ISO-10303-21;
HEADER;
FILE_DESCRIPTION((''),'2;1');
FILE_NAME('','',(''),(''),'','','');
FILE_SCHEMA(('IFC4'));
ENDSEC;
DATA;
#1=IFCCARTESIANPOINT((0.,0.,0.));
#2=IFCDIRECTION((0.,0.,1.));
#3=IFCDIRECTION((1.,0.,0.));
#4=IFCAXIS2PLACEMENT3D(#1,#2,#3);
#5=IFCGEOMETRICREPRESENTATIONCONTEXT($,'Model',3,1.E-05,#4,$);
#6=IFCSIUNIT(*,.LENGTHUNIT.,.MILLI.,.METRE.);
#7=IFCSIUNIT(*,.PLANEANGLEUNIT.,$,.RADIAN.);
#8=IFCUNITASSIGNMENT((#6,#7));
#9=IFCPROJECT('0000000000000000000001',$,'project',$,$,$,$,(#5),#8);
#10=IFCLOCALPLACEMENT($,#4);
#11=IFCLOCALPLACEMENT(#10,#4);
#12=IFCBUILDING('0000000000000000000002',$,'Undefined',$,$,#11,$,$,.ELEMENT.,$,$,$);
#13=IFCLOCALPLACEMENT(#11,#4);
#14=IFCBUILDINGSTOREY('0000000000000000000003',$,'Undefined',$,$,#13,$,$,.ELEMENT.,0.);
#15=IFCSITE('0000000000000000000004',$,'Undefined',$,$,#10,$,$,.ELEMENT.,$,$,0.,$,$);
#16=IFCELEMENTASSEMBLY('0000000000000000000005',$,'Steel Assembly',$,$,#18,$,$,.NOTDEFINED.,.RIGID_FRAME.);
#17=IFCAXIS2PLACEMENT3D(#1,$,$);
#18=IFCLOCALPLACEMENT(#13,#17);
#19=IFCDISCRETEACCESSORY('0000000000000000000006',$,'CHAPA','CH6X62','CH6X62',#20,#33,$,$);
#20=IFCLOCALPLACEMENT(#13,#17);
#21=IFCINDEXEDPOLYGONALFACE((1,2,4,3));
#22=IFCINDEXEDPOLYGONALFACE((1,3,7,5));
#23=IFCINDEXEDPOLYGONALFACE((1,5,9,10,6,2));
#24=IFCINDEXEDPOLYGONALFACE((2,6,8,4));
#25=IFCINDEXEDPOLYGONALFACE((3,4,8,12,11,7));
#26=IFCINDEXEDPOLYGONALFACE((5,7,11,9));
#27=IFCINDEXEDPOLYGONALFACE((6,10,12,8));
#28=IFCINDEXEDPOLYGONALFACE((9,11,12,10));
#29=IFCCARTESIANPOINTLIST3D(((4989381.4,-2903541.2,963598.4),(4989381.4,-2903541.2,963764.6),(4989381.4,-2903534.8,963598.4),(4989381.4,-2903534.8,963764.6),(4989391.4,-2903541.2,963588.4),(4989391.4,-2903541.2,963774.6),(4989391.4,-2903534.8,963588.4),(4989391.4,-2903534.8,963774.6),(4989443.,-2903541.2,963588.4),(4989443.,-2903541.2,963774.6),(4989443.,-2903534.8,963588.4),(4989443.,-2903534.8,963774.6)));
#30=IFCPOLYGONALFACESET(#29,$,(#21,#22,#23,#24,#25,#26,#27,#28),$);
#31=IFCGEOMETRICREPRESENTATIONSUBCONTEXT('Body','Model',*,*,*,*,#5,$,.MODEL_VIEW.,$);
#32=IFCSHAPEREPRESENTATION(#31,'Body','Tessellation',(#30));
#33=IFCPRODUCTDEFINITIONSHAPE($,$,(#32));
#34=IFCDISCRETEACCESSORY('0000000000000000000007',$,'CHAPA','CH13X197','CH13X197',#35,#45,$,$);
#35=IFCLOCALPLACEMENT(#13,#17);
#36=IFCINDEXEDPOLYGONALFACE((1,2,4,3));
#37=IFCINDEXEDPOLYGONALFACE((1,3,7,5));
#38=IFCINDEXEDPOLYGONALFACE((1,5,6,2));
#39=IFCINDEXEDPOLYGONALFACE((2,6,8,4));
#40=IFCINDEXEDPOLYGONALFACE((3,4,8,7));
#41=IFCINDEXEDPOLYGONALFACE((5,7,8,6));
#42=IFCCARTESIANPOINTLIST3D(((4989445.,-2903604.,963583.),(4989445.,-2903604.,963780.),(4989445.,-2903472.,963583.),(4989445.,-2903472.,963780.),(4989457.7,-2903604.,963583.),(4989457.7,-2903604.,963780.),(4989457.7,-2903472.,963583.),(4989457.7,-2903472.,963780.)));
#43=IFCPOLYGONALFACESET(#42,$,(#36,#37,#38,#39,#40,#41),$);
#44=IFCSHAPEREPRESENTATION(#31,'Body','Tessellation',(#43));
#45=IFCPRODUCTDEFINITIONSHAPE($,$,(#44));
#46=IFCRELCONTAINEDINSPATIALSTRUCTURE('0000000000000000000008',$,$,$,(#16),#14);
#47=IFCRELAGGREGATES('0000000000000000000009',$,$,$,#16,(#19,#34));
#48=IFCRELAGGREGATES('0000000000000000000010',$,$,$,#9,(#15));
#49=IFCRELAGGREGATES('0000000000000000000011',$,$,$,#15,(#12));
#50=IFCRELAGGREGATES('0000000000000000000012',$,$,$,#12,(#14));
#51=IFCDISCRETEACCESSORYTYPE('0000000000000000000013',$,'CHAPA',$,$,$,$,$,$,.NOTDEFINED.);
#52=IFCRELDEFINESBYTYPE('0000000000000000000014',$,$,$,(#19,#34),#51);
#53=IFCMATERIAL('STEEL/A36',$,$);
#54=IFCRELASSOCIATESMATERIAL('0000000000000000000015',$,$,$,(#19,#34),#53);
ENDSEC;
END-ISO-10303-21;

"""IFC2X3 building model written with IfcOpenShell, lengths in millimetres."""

from ifc_helpers import new_model, si_unit, frame, origin_with_axes, place, context, subcontext, project, spatial, polyline, outline, extrude, material, type_object, element, aggregate, save


model = new_model("IFC2X3")

# Units and contexts
model_context = context("Model", 3, precision=1e-05, world=origin_with_axes())
body_context = subcontext(model_context, "Body", "Model", "MODEL_VIEW")
ifc_project = project(units=[si_unit("LENGTHUNIT", "METRE", prefix="MILLI"), si_unit("PLANEANGLEUNIT", "RADIAN")], contexts=[model_context])

# Site, building, storey
site_placement = place(None, origin_with_axes())
site = spatial("IfcSite", under=ifc_project, at=site_placement, Name="Undefined", CompositionType="ELEMENT", RefElevation=0.0)
building_placement = place(site_placement, origin_with_axes())
building = spatial("IfcBuilding", under=site, at=building_placement, Name="Undefined", CompositionType="ELEMENT")
storey_placement = place(building_placement, origin_with_axes())
storey = spatial("IfcBuildingStorey", under=building, at=storey_placement, Name="Undefined", CompositionType="ELEMENT", Elevation=0.0)

# Shared definitions
ifc_material = material(Name="STEEL/A36")
discrete_accessory_type = type_object("IfcDiscreteAccessoryType", Name="CHAPA")

# Element assembly
assembly_1_placement = place(storey_placement, origin_with_axes())
assembly_1 = element("IfcElementAssembly", 1, at=assembly_1_placement, inside=storey, Name="Steel Assembly", AssemblyPlace="NOTDEFINED", PredefinedType="RIGID_FRAME")

# Discrete accessories
discrete_accessory_1_placement = place(assembly_1_placement, frame((4989381.4, -2903538.0, 963774.6), z_axis=(0.0, 1.0, 0.0), x_axis=(1.0, 0.0, 0.0)))
discrete_accessory_1 = element("IfcDiscreteAccessory", 2, at=discrete_accessory_1_placement, type_object=discrete_accessory_type, material=ifc_material, Name="CHAPA", Description="CH6X62", ObjectType="CH6X62", context=body_context, shape_type="SweptSolid", body=[
    extrude(outline(polyline([(0.0, 10.0), (10.0, 0.0), (61.6, 0.0), (61.6, 186.2), (10.0, 186.2), (0.0, 176.2), (0.0, 10.0)])), frame((0.0, 0.0, -3.2), z_axis=(0.0, 0.0, 1.0), x_axis=(1.0, 0.0, 0.0)), (0.0, 0.0, 1.0), 6.4),
])
discrete_accessory_2_placement = place(assembly_1_placement, frame((4989451.3, -2903538.0, 963780.0), z_axis=(1.0, 0.0, 0.0), x_axis=(0.0, 0.0, -1.0)))
discrete_accessory_2 = element("IfcDiscreteAccessory", 3, at=discrete_accessory_2_placement, type_object=discrete_accessory_type, material=ifc_material, Name="CHAPA", Description="CH13X197", ObjectType="CH13X197", context=body_context, shape_type="SweptSolid", body=[
    extrude(outline(polyline([(197.0, -66.0), (0.0, -66.0), (0.0, 66.0), (197.0, 66.0), (197.0, -66.0)])), frame((0.0, 0.0, -6.3), z_axis=(0.0, 0.0, 1.0), x_axis=(1.0, 0.0, 0.0)), (0.0, 0.0, 1.0), 12.7),
])
aggregate(assembly_1, [discrete_accessory_1, discrete_accessory_2])

save(model, "model.ifc")
